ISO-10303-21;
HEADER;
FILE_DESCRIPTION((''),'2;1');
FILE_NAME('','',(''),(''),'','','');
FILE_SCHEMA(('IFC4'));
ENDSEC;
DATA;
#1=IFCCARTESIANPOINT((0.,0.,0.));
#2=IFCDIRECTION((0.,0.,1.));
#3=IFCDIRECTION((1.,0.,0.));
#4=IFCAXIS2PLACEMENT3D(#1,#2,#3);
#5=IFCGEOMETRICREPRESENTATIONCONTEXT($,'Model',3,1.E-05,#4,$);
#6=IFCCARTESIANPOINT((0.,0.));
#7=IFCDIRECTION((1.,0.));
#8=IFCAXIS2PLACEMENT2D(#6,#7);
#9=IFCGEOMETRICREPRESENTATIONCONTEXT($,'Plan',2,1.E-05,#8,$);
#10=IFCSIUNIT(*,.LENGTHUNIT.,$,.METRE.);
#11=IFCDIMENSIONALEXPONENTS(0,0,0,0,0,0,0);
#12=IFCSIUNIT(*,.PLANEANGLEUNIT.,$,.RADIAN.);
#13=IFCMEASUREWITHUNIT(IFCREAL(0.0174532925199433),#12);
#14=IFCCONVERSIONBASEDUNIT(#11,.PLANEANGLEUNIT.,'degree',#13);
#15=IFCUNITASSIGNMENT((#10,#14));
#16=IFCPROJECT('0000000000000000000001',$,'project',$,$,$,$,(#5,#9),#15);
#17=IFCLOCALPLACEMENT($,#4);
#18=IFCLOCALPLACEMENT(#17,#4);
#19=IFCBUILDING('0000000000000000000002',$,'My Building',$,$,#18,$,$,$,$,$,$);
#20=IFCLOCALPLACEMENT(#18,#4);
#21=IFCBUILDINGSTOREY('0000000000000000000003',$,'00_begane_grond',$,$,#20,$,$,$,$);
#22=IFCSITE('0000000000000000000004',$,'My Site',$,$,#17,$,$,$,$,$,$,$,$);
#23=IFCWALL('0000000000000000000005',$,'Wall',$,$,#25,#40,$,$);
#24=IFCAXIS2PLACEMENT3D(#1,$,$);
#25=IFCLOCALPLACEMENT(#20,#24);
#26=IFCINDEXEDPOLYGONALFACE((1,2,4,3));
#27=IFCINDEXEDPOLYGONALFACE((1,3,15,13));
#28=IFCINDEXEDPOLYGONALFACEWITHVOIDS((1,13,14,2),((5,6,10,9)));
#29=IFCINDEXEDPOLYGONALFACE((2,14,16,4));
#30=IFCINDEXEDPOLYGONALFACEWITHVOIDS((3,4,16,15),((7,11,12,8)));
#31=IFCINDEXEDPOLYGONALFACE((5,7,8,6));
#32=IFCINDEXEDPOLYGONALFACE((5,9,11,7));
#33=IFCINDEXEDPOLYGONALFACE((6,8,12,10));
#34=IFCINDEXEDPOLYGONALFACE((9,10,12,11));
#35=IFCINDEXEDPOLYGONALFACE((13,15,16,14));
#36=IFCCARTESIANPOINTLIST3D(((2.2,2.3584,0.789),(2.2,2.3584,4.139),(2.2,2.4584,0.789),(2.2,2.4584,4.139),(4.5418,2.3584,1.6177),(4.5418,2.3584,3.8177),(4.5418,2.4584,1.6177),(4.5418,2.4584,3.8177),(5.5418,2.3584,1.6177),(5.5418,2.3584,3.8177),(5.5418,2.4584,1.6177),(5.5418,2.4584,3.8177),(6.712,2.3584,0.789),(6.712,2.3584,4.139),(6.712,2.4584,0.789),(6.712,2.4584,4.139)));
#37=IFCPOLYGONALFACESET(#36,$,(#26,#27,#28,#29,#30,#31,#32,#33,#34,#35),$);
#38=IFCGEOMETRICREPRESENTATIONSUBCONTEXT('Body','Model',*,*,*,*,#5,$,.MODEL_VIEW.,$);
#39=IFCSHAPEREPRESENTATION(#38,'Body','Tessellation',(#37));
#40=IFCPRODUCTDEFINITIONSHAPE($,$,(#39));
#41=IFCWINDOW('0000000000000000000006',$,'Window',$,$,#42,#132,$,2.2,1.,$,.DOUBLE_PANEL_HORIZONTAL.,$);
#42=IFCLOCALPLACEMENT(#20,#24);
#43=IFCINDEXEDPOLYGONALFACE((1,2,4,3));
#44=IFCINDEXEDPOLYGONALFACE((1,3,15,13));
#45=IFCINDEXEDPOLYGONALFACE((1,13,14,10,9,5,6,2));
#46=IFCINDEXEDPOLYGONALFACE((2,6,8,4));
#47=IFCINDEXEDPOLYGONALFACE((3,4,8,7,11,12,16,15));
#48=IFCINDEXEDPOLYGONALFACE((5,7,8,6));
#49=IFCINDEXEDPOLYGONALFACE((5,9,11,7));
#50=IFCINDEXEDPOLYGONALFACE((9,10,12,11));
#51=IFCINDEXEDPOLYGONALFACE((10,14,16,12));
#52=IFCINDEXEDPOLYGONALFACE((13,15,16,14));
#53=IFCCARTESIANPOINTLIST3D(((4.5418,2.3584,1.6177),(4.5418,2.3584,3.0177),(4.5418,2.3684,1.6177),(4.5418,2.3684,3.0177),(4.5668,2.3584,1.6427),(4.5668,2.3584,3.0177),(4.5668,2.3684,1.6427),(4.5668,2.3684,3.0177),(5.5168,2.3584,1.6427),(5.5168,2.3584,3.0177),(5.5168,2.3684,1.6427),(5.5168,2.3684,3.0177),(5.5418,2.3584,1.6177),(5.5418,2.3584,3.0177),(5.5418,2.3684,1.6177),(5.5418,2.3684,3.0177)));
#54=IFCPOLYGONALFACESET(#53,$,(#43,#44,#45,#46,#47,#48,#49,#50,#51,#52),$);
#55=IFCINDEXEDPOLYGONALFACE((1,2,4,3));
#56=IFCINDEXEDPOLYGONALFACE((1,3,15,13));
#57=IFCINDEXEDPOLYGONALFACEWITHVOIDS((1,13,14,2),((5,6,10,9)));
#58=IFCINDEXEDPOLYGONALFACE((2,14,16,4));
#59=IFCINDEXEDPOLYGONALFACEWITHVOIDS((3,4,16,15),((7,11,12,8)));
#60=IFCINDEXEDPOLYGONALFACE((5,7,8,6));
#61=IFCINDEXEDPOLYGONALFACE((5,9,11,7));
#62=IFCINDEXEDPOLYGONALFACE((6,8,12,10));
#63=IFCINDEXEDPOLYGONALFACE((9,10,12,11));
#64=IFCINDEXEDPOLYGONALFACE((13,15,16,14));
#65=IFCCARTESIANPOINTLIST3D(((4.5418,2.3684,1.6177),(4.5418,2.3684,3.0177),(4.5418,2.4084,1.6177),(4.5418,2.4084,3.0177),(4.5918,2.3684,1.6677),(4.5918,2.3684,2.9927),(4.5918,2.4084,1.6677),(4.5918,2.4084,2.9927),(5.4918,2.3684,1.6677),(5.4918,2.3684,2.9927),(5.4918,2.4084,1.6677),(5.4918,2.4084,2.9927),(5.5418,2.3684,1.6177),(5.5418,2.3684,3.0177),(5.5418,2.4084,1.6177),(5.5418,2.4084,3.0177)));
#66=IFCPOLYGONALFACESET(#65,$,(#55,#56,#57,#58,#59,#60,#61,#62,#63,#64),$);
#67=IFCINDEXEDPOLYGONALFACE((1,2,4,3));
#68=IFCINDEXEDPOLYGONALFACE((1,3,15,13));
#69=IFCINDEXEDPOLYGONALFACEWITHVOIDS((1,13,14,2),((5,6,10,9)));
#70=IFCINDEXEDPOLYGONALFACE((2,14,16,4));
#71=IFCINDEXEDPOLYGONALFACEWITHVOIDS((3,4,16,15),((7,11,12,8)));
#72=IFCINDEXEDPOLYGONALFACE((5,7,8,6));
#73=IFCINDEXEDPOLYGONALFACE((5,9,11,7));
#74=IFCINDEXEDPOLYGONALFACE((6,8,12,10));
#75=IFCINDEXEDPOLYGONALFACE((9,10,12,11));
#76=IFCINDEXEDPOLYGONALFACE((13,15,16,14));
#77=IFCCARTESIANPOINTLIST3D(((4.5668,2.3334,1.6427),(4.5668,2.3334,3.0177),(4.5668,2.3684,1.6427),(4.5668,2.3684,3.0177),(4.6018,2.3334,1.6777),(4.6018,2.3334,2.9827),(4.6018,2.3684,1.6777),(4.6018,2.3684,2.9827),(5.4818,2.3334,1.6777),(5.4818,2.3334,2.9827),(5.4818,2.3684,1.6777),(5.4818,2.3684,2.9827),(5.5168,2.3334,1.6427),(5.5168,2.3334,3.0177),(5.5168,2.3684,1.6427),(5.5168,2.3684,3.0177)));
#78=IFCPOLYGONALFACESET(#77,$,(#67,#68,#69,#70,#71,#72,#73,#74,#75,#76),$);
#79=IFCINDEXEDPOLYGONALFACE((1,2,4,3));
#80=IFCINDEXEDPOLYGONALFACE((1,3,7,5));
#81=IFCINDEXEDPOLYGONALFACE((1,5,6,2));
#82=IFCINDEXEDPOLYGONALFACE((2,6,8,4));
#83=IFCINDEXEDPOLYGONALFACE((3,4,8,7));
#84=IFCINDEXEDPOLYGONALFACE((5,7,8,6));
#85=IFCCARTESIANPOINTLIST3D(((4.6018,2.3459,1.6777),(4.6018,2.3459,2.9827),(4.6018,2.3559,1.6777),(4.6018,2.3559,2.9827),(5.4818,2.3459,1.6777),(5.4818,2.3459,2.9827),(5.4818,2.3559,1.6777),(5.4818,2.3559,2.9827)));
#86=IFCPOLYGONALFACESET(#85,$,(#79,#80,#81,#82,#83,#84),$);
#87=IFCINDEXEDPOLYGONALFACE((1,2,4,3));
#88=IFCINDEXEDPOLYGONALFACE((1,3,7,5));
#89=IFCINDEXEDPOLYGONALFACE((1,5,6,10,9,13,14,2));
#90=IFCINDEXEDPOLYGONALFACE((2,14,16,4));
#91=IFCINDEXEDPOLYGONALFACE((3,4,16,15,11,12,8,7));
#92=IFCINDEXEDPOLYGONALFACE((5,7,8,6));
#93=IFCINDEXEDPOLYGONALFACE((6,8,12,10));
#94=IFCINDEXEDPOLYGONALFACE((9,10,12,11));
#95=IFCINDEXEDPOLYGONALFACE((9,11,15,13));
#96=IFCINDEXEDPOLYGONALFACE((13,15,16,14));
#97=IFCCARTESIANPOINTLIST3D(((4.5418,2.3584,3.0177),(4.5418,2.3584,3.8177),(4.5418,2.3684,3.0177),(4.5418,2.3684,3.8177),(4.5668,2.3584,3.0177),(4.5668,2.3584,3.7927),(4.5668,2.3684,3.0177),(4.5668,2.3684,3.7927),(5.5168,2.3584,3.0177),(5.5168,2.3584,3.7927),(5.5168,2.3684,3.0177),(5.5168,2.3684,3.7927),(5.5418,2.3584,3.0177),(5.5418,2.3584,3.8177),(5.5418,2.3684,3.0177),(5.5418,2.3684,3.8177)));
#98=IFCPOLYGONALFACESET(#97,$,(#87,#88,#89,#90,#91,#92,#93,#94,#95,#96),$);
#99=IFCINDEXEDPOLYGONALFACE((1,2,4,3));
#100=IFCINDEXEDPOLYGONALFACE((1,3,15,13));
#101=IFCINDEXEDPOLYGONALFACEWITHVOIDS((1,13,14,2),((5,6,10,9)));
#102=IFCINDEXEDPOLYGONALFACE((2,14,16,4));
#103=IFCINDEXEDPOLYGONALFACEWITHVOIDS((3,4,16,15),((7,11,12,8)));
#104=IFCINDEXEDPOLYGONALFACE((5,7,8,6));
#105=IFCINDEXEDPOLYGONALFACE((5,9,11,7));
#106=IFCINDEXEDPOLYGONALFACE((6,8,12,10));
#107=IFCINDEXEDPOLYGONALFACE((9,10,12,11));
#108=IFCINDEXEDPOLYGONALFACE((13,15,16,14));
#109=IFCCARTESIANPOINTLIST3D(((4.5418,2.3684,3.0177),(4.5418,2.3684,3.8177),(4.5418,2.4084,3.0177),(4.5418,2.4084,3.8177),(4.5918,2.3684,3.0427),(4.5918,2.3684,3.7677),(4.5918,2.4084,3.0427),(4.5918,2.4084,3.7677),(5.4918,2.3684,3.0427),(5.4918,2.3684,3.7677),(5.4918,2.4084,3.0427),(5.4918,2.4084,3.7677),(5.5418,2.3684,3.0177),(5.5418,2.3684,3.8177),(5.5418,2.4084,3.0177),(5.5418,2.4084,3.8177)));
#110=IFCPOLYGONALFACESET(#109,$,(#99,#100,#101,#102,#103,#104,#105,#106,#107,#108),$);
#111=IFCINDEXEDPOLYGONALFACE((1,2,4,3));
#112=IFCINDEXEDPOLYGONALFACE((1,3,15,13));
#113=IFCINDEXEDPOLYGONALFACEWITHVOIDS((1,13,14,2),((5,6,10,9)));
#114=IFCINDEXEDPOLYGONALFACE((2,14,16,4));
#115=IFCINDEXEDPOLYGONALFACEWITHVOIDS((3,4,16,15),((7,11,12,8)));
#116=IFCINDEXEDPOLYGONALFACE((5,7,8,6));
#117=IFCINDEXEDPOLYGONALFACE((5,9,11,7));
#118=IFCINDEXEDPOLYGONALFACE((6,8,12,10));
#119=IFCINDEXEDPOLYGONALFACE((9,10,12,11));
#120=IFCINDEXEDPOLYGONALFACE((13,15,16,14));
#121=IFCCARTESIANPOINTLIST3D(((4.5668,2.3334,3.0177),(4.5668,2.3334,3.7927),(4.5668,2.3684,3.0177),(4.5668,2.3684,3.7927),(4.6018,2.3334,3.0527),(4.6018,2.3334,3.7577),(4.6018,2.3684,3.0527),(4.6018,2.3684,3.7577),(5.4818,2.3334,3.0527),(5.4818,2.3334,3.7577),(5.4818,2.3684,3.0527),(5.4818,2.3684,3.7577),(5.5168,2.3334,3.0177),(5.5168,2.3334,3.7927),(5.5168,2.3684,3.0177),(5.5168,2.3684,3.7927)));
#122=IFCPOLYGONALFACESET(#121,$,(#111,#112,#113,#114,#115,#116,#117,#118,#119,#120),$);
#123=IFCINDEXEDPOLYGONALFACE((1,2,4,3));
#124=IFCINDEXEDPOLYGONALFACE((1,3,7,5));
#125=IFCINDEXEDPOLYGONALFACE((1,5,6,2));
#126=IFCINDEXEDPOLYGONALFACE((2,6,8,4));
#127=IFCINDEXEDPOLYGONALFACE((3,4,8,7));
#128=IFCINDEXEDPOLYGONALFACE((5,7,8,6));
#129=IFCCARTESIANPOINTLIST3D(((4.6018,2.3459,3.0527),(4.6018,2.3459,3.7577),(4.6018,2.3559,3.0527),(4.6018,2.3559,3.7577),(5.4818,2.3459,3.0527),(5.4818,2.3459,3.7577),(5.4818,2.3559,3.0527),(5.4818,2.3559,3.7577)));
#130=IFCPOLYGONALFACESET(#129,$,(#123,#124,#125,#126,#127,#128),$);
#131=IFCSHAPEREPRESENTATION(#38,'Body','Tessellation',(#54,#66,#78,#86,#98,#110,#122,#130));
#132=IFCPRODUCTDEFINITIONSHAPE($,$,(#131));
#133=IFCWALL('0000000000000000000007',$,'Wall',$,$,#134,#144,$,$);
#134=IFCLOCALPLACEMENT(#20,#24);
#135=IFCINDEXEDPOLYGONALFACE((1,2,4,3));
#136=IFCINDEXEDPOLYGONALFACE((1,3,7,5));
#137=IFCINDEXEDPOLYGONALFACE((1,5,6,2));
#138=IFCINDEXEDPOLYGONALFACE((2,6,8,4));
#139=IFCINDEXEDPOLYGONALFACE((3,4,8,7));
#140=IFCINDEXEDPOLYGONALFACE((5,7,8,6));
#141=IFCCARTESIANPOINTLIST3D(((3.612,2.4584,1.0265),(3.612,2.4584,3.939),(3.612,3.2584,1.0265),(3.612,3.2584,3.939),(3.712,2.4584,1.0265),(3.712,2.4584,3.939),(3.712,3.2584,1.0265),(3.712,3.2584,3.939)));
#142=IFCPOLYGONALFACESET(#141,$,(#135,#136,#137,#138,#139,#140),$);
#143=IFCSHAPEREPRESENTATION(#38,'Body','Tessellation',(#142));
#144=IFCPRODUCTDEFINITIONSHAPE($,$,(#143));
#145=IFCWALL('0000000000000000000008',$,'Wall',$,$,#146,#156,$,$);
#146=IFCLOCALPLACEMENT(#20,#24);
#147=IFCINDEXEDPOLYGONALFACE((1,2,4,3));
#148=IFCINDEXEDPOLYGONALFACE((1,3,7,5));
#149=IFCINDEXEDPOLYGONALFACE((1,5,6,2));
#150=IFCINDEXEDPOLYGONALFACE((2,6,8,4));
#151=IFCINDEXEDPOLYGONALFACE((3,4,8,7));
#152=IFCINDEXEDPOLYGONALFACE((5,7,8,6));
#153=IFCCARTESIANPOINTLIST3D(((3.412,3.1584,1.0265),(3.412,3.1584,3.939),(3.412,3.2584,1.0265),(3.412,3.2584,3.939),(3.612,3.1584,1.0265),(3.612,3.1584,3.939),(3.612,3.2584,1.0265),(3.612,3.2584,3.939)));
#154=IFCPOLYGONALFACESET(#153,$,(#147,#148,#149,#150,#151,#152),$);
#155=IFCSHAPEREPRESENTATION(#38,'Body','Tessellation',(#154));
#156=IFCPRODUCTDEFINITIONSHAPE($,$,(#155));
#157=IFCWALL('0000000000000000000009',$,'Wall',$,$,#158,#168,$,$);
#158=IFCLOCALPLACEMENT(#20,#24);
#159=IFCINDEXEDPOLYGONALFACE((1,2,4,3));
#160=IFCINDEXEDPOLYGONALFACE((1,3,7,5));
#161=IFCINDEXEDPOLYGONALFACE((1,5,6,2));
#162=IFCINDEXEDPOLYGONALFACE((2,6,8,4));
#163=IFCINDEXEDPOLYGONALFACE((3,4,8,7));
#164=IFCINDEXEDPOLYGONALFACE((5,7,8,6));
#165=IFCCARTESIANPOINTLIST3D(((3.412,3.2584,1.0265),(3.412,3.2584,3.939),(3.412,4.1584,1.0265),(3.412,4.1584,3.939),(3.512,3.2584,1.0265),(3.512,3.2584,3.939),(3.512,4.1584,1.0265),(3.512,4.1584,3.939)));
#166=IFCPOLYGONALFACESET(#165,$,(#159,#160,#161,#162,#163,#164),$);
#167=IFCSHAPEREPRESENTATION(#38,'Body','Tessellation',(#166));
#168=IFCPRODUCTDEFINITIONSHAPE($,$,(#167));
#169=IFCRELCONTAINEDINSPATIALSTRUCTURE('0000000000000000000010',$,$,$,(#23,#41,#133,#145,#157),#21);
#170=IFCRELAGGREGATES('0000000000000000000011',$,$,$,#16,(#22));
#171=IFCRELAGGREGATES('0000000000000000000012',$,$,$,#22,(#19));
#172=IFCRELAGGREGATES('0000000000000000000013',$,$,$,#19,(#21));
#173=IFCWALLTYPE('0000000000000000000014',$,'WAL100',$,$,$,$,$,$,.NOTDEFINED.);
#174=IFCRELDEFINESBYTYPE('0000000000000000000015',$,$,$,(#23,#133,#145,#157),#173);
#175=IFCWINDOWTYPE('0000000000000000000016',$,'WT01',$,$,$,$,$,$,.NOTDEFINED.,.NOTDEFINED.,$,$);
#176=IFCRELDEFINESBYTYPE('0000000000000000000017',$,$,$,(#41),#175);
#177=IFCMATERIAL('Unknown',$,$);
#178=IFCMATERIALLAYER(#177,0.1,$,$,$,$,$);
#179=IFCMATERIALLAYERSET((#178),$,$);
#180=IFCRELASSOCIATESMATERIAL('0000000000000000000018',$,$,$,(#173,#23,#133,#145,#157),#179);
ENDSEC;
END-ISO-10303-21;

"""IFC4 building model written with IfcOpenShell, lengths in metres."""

from ifc_helpers import new_model, entity, si_unit, converted_unit, frame, origin_with_axes, origin_2d_with_axis, place, context, subcontext, project, spatial, line, indexed_curve, outline, extrude, clip, halfspace, shape, source, transform, mapped, material, layer, layer_set, layer_usage, type_object, type_shapes, element, fill, save


model = new_model("IFC4")

# Units and contexts
model_context = context("Model", 3, precision=1e-05, world=origin_with_axes())
plan_context = context("Plan", 2, precision=1e-05, world=origin_2d_with_axis())
body_context_1 = subcontext(model_context, "Body", "Model", "MODEL_VIEW")
body_context_2 = subcontext(plan_context, "Body", "Plan", "PLAN_VIEW")
ifc_project = project(units=[si_unit("LENGTHUNIT", "METRE"), converted_unit("PLANEANGLEUNIT", "degree", entity("IfcReal", 0.0174532925199433), si_unit("PLANEANGLEUNIT", "RADIAN"), dimensions=[0, 0, 0, 0, 0, 0, 0])], contexts=[model_context, plan_context])

# Site, building, storey
site_placement = place(None, origin_with_axes())
site = spatial("IfcSite", under=ifc_project, at=site_placement, Name="My Site")
building_placement = place(site_placement, origin_with_axes())
building = spatial("IfcBuilding", under=site, at=building_placement, Name="My Building")
storey_placement = place(building_placement, origin_with_axes())
storey = spatial("IfcBuildingStorey", under=building, at=storey_placement, Name="00_begane_grond")

# Shared definitions
ifc_material = material(Name="Unknown")

# Wall, opening, window
ifc_layer_1 = layer(ifc_material, 0.1)
ifc_layer_set_1 = layer_set([ifc_layer_1])
ifc_layer_usage_1 = layer_usage(ifc_layer_set_1, "AXIS2", "POSITIVE", 0.0)
wall_type_1 = type_object("IfcWallType", Name="WAL100", PredefinedType="NOTDEFINED", material=ifc_layer_set_1)
wall_1_placement = place(storey_placement, frame((6.712, 2.4584, 0.789), z_axis=(0.0, 0.0, 1.0), x_axis=(-1.0, 0.0, 0.0)))
wall_1 = element("IfcWall", 1, at=wall_1_placement, inside=storey, type_object=wall_type_1, material=ifc_layer_usage_1, Name="Wall", context=body_context_1, shape_type="SweptSolid", body=[
    extrude(outline(indexed_curve([(0.0, 0.0), (0.0, 0.1), (4.512, 0.1), (4.512, 0.0), (0.0, 0.0)], self_intersect=False)), origin_with_axes(), (0.0, 0.0, 1.0), 3.35),
])
shared_shape_1 = source(origin_with_axes(), body_context_1, "Body", "SweptSolid", [
    extrude(outline(indexed_curve([(0.0, 0.0), (1.0, 0.0), (1.0, 2.2), (0.0, 2.2)], segments=[line(1, 2, 3, 4, 1)])), frame((0.0, -0.1, 0.0), z_axis=(0.0, -1.0, 0.0), x_axis=(1.0, 0.0, 0.0)), (0.0, 0.0, -1.0), 0.3),
])
opening_1_placement = place(wall_1_placement, frame((1.1702, 0.0, 0.8286), z_axis=(0.0, 0.0, 1.0), x_axis=(1.0, 0.0, 0.0)))
opening_1 = element("IfcOpeningElement", 2, at=opening_1_placement, cuts=wall_1, PredefinedType="OPENING", context=body_context_1, shape_type="MappedRepresentation", body=[
    mapped(shared_shape_1, transform((0.0, 0.0, 0.0), x_axis=(1.0, 0.0, 0.0), y_axis=(0.0, 1.0, 0.0), z_axis=(0.0, 0.0, 1.0), scale=1.0)),
])
window_type = type_object("IfcWindowType", Name="WT01", PartitioningType="NOTDEFINED", PredefinedType="NOTDEFINED")
shared_shape_2 = source(origin_with_axes(), body_context_1, "Body", "SweptSolid", [
    extrude(outline(indexed_curve([(1.0, 1.4), (1.0, 0.0), (0.0, 0.0), (0.0, 1.4), (0.025, 1.4), (0.025, 0.025), (0.975, 0.025), (0.975, 1.4)], segments=[line(1, 2, 3, 4, 5, 6, 7, 8, 1)])), frame((0.0, 0.09, 0.0), z_axis=(0.0, -1.0, 0.0), x_axis=(1.0, 0.0, 0.0)), (0.0, 0.0, -1.0), 0.01),
    extrude(outline(indexed_curve([(0.0, 0.0), (1.0, 0.0), (1.0, 1.4), (0.0, 1.4)], segments=[line(1, 2, 3, 4, 1)]), holes=[indexed_curve([(0.05, 0.05), (0.95, 0.05), (0.95, 1.375), (0.05, 1.375)], segments=[line(1, 2, 3, 4, 1)])]), frame((0.0, 0.05, 0.0), z_axis=(0.0, -1.0, 0.0), x_axis=(1.0, 0.0, 0.0)), (0.0, 0.0, -1.0), 0.04),
    extrude(outline(indexed_curve([(0.0, 0.0), (0.95, 0.0), (0.95, 1.375), (0.0, 1.375)], segments=[line(1, 2, 3, 4, 1)]), holes=[indexed_curve([(0.035, 0.035), (0.915, 0.035), (0.915, 1.34), (0.035, 1.34)], segments=[line(1, 2, 3, 4, 1)])]), frame((0.025, 0.09, 0.025), z_axis=(0.0, -1.0, 0.0), x_axis=(1.0, 0.0, 0.0)), (0.0, 0.0, -1.0), 0.035),
    extrude(outline(indexed_curve([(0.035, 0.035), (0.915, 0.035), (0.915, 1.34), (0.035, 1.34)], segments=[line(1, 2, 3, 4, 1)])), frame((0.025, 0.1025, 0.025), z_axis=(0.0, -1.0, 0.0), x_axis=(1.0, 0.0, 0.0)), (0.0, 0.0, -1.0), 0.01),
    extrude(outline(indexed_curve([(0.0, 0.0), (0.0, 0.8), (1.0, 0.8), (1.0, 0.0), (0.975, 0.0), (0.975, 0.775), (0.025, 0.775), (0.025, 0.0)], segments=[line(1, 2, 3, 4, 5, 6, 7, 8, 1)])), frame((0.0, 0.09, 1.4), z_axis=(0.0, -1.0, 0.0), x_axis=(1.0, 0.0, 0.0)), (0.0, 0.0, -1.0), 0.01),
    extrude(outline(indexed_curve([(0.0, 0.0), (1.0, 0.0), (1.0, 0.8), (0.0, 0.8)], segments=[line(1, 2, 3, 4, 1)]), holes=[indexed_curve([(0.05, 0.025), (0.95, 0.025), (0.95, 0.75), (0.05, 0.75)], segments=[line(1, 2, 3, 4, 1)])]), frame((0.0, 0.05, 1.4), z_axis=(0.0, -1.0, 0.0), x_axis=(1.0, 0.0, 0.0)), (0.0, 0.0, -1.0), 0.04),
    extrude(outline(indexed_curve([(0.0, 0.0), (0.95, 0.0), (0.95, 0.775), (0.0, 0.775)], segments=[line(1, 2, 3, 4, 1)]), holes=[indexed_curve([(0.035, 0.035), (0.915, 0.035), (0.915, 0.74), (0.035, 0.74)], segments=[line(1, 2, 3, 4, 1)])]), frame((0.025, 0.09, 1.4), z_axis=(0.0, -1.0, 0.0), x_axis=(1.0, 0.0, 0.0)), (0.0, 0.0, -1.0), 0.035),
    extrude(outline(indexed_curve([(0.035, 0.035), (0.915, 0.035), (0.915, 0.74), (0.035, 0.74)], segments=[line(1, 2, 3, 4, 1)])), frame((0.025, 0.1025, 1.4), z_axis=(0.0, -1.0, 0.0), x_axis=(1.0, 0.0, 0.0)), (0.0, 0.0, -1.0), 0.01),
])
shared_shape_3 = source(origin_with_axes(), body_context_2, "Body", "Curve2D", [
    entity("IfcIndexedPolyCurve", entity("IfcCartesianPointList2D", [[0.05, 0.05], [0.95, 0.05]])),
    entity("IfcIndexedPolyCurve", entity("IfcCartesianPointList2D", [[0.0, 0.1], [0.025, 0.1], [0.025, 0.09], [0.05, 0.09], [0.05, 0.05], [0.0, 0.05]]), [entity("IfcLineIndex", [1, 2, 3, 4, 5, 6, 1])]),
    entity("IfcIndexedPolyCurve", entity("IfcCartesianPointList2D", [[1.0, 0.1], [0.975, 0.1], [0.975, 0.09], [0.95, 0.09], [0.95, 0.05], [1.0, 0.05]]), [entity("IfcLineIndex", [1, 2, 3, 4, 5, 6, 1])]),
    entity("IfcIndexedPolyCurve", entity("IfcCartesianPointList2D", [[0.025, 0.09], [0.06, 0.09], [0.06, 0.125], [0.025, 0.125]]), [entity("IfcLineIndex", [1, 2, 3, 4, 1])]),
    entity("IfcIndexedPolyCurve", entity("IfcCartesianPointList2D", [[0.975, 0.09], [0.94, 0.09], [0.94, 0.125], [0.975, 0.125]]), [entity("IfcLineIndex", [1, 2, 3, 4, 1])]),
    entity("IfcIndexedPolyCurve", entity("IfcCartesianPointList2D", [[0.06, 0.09], [0.94, 0.09]])),
    entity("IfcIndexedPolyCurve", entity("IfcCartesianPointList2D", [[0.06, 0.125], [0.94, 0.125]])),
    entity("IfcIndexedPolyCurve", entity("IfcCartesianPointList2D", [[0.06, 0.1075], [0.94, 0.1075]])),
])
type_shapes(window_type, [shared_shape_2, shared_shape_3])
window_placement = place(opening_1_placement, frame((0.0, 0.0, 0.0), z_axis=(0.0, 0.0, 1.0), x_axis=(1.0, 0.0, 0.0)))
window = element("IfcWindow", 3, at=window_placement, inside=storey, type_object=window_type, Name="Window", OverallHeight=2.2, OverallWidth=1.0, PartitioningType="DOUBLE_PANEL_HORIZONTAL", shapes=[
    shape(body_context_1, "Body", "MappedRepresentation", [mapped(shared_shape_2, transform((0.0, 0.0, 0.0), x_axis=(1.0, 0.0, 0.0), y_axis=(0.0, 1.0, 0.0), z_axis=(0.0, 0.0, 1.0), scale=1.0))]),
    shape(body_context_2, "Body", "MappedRepresentation", [mapped(shared_shape_3, transform((0.0, 0.0, 0.0), x_axis=(1.0, 0.0, 0.0), y_axis=(0.0, 1.0, 0.0), z_axis=(0.0, 0.0, 1.0), scale=1.0))]),
])
fill(opening_1, window)

# Walls
ifc_layer_usage_2 = layer_usage(ifc_layer_set_1, "AXIS2", "POSITIVE", 0.0)
wall_2_placement = place(storey_placement, frame((3.712, 2.4584, 1.0265), z_axis=(0.0, 0.0, 1.0), x_axis=(0.000001, 1.0, 0.0)))
element("IfcWall", 4, at=wall_2_placement, inside=storey, type_object=wall_type_1, material=ifc_layer_usage_2, Name="Wall", context=body_context_1, shape_type="Clipping", body=[
    clip(extrude(outline(indexed_curve([(0.0, 0.0), (0.0, 0.1), (0.8, 0.1), (0.8, 0.0), (0.0, 0.0)], self_intersect=False)), origin_with_axes(), (0.0, 0.0, 1.0), 3.939), halfspace(frame((0.0, 0.0, 2.9125), z_axis=(0.0, 0.0, 1.0), x_axis=(-1.0, 0.0, 0.0)), False)),
])
ifc_layer_usage_3 = layer_usage(ifc_layer_set_1, "AXIS2", "POSITIVE", 0.0)
wall_3_placement = place(storey_placement, frame((3.612, 3.2584, 1.0265), z_axis=(0.0, 0.0, 1.0), x_axis=(-1.0, 0.000001, 0.0)))
element("IfcWall", 5, at=wall_3_placement, inside=storey, type_object=wall_type_1, material=ifc_layer_usage_3, Name="Wall", context=body_context_1, shape_type="Clipping", body=[
    clip(extrude(outline(indexed_curve([(0.0, 0.0), (0.0, 0.1), (0.2, 0.1), (0.2, 0.0), (0.0, 0.0)], self_intersect=False)), origin_with_axes(), (0.0, 0.0, 1.0), 3.939), halfspace(frame((0.0, 0.0, 2.9125), z_axis=(0.0, 0.0, 1.0), x_axis=(-1.0, 0.0, 0.0)), False)),
])
ifc_layer_usage_4 = layer_usage(ifc_layer_set_1, "AXIS2", "POSITIVE", 0.0)
wall_4_placement = place(storey_placement, frame((3.512, 3.2584, 1.0265), z_axis=(0.0, 0.0, 1.0), x_axis=(0.000001, 1.0, 0.0)))
element("IfcWall", 6, at=wall_4_placement, inside=storey, type_object=wall_type_1, material=ifc_layer_usage_4, Name="Wall", context=body_context_1, shape_type="Clipping", body=[
    clip(extrude(outline(indexed_curve([(0.0, 0.0), (0.0, 0.1), (0.9, 0.1), (0.9, 0.0), (0.0, 0.0)], self_intersect=False)), origin_with_axes(), (0.0, 0.0, 1.0), 3.939), halfspace(frame((0.0, 0.0, 2.9125), z_axis=(0.0, 0.0, 1.0), x_axis=(-1.0, 0.0, 0.0)), False)),
])

save(model, "model.ifc")
